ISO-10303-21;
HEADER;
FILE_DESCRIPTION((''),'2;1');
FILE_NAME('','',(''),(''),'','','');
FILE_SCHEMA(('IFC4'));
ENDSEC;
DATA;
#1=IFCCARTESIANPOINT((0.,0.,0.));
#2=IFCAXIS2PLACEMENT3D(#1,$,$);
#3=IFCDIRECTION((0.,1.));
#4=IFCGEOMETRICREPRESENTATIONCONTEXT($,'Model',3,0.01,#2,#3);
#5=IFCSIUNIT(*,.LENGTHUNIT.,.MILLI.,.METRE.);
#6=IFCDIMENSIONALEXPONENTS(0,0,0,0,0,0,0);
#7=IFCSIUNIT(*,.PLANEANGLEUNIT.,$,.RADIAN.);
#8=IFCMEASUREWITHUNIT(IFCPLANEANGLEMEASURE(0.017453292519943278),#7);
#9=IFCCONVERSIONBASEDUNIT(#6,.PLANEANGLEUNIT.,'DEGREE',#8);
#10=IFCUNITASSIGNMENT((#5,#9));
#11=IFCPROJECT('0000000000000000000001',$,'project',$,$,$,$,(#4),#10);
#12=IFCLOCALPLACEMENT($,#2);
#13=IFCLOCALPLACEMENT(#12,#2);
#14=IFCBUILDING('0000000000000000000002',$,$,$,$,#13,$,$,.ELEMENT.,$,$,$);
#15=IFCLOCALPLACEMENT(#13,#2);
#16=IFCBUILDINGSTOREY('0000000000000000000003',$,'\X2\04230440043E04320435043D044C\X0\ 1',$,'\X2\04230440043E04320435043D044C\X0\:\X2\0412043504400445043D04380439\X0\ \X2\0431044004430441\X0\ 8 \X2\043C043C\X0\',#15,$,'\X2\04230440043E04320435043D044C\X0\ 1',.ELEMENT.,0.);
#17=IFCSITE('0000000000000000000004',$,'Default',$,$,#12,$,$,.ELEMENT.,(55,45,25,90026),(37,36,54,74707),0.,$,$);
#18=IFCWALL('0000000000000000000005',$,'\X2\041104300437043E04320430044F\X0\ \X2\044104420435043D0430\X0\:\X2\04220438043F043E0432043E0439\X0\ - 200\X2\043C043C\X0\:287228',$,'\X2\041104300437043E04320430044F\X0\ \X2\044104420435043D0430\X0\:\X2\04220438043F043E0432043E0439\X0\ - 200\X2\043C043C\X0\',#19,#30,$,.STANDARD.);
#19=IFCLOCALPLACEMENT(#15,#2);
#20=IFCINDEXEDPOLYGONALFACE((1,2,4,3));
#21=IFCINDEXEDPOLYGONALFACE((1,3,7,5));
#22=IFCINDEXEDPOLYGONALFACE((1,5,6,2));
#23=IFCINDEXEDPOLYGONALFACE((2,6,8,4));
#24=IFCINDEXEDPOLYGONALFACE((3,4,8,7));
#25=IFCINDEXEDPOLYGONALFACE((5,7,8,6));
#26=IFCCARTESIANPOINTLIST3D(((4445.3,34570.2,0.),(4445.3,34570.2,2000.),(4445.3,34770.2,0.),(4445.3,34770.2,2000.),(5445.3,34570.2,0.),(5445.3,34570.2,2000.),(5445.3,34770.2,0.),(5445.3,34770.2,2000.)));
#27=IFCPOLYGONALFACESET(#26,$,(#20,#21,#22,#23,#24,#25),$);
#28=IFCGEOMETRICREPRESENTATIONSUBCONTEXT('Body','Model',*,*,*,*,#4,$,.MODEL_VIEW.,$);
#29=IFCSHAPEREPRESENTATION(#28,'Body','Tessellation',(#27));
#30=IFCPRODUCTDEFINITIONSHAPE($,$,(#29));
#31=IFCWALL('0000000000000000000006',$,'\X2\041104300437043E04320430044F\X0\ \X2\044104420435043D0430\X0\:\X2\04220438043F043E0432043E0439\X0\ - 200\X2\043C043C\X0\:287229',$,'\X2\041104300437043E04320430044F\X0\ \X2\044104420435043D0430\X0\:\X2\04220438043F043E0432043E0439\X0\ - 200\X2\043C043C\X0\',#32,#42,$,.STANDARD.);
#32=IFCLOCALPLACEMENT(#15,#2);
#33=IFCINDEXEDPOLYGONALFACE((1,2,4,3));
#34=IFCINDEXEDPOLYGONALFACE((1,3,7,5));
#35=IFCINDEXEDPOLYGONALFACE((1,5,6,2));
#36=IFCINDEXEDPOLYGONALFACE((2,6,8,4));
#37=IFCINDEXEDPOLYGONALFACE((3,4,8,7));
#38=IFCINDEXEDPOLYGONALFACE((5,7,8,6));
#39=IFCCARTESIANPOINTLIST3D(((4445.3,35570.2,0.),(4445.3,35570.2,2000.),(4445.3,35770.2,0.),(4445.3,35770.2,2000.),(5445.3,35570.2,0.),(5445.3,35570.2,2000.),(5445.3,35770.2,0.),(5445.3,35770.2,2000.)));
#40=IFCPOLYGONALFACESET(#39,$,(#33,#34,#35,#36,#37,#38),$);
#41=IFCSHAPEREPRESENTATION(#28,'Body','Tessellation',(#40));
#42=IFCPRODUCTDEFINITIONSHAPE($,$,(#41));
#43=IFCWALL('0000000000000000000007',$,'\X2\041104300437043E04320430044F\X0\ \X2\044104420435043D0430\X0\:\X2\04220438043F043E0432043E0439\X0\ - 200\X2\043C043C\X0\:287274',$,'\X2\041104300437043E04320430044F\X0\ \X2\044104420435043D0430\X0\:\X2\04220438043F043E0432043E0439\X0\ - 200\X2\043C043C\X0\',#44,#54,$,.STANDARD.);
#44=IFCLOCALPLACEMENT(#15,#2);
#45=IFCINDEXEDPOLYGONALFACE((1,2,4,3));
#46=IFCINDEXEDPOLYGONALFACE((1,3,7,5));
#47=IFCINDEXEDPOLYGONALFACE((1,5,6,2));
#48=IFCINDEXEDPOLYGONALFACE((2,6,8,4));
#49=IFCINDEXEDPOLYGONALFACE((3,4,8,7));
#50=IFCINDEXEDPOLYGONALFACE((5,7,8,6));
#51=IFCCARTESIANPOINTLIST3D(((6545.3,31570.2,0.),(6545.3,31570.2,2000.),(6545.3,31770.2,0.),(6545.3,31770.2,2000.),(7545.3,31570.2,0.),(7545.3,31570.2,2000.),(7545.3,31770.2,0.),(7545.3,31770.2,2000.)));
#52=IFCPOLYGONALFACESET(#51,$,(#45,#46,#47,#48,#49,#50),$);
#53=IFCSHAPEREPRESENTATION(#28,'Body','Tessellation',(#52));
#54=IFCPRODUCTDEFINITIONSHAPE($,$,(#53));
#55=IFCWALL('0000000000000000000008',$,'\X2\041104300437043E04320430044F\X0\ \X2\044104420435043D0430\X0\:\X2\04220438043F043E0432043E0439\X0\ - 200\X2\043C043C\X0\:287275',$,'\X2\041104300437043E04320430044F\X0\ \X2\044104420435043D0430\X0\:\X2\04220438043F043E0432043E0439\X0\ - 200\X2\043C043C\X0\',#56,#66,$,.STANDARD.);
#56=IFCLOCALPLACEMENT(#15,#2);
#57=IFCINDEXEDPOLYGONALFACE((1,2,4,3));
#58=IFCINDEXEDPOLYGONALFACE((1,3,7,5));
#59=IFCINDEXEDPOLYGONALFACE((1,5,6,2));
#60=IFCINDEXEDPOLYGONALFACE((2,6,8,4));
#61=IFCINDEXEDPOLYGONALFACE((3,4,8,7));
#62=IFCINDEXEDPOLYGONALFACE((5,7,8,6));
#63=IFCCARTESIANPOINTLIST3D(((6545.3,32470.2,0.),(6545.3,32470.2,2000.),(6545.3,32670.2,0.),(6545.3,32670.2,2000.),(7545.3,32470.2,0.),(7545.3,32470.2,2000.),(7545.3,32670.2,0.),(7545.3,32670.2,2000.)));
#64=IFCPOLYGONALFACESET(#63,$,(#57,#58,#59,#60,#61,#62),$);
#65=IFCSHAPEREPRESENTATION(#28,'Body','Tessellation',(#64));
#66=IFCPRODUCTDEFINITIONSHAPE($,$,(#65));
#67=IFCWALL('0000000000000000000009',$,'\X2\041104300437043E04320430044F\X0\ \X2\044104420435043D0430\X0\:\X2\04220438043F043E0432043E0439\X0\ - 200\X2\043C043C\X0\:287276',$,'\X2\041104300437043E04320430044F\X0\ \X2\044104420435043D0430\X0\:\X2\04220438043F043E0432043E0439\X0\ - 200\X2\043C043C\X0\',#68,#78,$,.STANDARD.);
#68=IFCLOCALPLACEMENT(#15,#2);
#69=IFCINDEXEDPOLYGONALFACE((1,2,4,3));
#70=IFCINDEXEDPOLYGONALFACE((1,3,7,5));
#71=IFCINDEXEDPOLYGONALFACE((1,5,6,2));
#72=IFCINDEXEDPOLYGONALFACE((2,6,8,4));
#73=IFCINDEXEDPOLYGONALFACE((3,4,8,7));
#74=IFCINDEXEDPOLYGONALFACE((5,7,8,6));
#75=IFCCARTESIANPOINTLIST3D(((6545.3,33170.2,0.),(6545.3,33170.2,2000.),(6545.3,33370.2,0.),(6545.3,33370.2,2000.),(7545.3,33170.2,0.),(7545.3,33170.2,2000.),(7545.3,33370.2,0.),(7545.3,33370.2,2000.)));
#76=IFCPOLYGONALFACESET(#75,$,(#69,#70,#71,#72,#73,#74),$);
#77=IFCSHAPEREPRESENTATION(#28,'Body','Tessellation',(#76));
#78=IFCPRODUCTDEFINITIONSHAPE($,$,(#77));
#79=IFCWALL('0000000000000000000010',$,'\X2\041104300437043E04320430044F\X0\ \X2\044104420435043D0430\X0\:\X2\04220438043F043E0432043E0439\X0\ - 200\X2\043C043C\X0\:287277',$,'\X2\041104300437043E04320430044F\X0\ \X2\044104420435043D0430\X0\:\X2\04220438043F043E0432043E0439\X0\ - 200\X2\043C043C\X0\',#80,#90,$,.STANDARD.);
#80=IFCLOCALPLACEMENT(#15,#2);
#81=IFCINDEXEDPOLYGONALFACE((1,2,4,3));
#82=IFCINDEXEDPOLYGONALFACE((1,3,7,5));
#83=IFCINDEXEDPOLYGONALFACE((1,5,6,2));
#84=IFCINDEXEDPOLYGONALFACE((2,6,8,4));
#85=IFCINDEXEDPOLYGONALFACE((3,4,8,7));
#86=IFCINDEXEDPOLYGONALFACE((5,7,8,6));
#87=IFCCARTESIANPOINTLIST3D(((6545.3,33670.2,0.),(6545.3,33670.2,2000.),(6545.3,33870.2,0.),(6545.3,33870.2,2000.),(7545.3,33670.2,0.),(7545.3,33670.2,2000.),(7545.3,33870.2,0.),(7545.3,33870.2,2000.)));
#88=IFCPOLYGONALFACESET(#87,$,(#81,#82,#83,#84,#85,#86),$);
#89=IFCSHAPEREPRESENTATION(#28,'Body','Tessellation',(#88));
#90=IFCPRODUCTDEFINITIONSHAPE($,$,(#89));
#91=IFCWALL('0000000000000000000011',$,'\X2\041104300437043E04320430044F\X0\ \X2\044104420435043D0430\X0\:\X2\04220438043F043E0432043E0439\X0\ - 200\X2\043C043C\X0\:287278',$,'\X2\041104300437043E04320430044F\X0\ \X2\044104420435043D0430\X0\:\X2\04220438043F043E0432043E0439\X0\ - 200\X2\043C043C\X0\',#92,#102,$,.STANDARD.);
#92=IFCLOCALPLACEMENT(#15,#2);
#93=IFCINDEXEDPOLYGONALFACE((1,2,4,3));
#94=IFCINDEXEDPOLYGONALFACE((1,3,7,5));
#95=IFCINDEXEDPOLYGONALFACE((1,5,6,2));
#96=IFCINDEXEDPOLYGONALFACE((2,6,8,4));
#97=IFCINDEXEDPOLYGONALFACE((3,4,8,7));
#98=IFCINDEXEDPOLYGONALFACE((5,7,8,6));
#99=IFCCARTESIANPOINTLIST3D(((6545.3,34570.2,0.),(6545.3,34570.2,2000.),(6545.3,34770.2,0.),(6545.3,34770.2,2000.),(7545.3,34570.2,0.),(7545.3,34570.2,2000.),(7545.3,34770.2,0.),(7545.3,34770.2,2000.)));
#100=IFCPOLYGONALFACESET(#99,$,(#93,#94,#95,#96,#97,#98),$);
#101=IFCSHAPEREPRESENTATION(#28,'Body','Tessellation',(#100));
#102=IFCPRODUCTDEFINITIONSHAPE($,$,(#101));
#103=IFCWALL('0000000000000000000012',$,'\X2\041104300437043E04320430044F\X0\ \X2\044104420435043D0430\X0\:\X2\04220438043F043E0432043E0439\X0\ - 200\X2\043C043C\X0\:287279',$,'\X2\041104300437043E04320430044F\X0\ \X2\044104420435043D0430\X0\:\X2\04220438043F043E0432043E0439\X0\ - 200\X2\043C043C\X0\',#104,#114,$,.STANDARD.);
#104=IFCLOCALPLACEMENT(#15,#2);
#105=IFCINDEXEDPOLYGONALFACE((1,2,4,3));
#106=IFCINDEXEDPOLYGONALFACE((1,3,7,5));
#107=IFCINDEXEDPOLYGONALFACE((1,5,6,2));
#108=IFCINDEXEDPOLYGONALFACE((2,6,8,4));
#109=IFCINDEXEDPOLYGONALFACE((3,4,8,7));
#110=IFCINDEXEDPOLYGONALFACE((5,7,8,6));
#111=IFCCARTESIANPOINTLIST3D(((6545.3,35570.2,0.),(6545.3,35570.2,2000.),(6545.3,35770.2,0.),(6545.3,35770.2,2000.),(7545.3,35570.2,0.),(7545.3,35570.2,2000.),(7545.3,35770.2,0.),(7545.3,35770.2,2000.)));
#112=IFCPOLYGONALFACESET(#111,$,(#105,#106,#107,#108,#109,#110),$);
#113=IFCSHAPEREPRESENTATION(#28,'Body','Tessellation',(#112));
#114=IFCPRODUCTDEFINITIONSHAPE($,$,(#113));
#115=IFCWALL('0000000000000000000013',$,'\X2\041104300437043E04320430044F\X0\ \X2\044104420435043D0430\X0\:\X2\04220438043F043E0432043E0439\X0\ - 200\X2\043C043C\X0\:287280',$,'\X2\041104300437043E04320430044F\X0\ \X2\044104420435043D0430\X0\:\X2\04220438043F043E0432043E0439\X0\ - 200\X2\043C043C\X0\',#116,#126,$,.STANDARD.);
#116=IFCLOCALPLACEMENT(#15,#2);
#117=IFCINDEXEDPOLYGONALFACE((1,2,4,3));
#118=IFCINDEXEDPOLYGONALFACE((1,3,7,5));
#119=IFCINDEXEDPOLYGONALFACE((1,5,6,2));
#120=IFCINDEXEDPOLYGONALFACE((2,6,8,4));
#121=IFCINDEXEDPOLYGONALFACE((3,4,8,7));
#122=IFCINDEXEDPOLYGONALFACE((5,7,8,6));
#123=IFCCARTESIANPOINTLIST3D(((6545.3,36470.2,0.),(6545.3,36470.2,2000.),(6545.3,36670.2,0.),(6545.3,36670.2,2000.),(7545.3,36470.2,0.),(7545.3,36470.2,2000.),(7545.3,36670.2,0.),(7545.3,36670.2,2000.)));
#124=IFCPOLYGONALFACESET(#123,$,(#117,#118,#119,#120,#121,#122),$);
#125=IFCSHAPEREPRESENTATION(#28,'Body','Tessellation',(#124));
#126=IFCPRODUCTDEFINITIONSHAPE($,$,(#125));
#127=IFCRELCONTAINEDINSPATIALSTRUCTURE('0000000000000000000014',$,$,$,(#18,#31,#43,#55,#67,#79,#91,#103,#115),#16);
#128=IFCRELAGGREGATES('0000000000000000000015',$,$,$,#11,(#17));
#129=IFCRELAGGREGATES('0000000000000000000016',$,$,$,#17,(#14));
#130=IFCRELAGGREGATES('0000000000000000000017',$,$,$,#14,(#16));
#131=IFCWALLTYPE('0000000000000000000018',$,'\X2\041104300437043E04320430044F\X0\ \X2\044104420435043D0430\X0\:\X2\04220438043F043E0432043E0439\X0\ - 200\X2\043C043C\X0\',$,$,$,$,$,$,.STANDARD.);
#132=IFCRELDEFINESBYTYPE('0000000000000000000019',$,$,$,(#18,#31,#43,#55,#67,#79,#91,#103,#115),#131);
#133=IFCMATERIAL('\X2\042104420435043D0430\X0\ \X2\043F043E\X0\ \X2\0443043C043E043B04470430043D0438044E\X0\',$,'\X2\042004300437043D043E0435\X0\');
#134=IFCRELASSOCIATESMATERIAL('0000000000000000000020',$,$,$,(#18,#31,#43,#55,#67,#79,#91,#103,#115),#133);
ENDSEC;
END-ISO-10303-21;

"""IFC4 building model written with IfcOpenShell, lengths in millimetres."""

from ifc_helpers import new_model, entity, si_unit, converted_unit, direction, frame, origin, place, context, subcontext, project, spatial, indexed_curve, outline, extrude, material, type_object, element, save


model = new_model("IFC4")

# Units and contexts
model_context = context("Model", 3, precision=0.01, world=origin(), true_north=direction((0.0, 1.0)))
body_context = subcontext(model_context, "Body", "Model", "MODEL_VIEW")
ifc_project = project(units=[si_unit("LENGTHUNIT", "METRE", prefix="MILLI"), converted_unit("PLANEANGLEUNIT", "DEGREE", entity("IfcPlaneAngleMeasure", 0.017453292519943278), si_unit("PLANEANGLEUNIT", "RADIAN"), dimensions=[0, 0, 0, 0, 0, 0, 0])], contexts=[model_context])

# Site, building, storey
site_placement = place(None, origin())
site = spatial("IfcSite", under=ifc_project, at=site_placement, Name="Default", CompositionType="ELEMENT", RefLatitude=(55, 45, 25, 90026), RefLongitude=(37, 36, 54, 74707), RefElevation=0.0)
building_placement = place(site_placement, origin())
building = spatial("IfcBuilding", under=site, at=building_placement, CompositionType="ELEMENT")
storey_placement = place(building_placement, origin())
storey = spatial("IfcBuildingStorey", under=building, at=storey_placement, Name="Уровень 1", ObjectType="Уровень:Верхний брус 8 мм", LongName="Уровень 1", CompositionType="ELEMENT", Elevation=0.0)

# Walls
ifc_material = material(Name="Стена по умолчанию", Category="Разное")
wall_type = type_object("IfcWallType", Name="Базовая стена:Типовой - 200мм", PredefinedType="STANDARD")
for number, where, name in (
    (1, (4445.3, 34670.2, 0.0), "Базовая стена:Типовой - 200мм:287228"),
    (2, (4445.3, 35670.2, 0.0), "Базовая стена:Типовой - 200мм:287229"),
):
    element("IfcWall", number, at=place(storey_placement, frame(where)), inside=storey, type_object=wall_type, material=ifc_material, Name=name, ObjectType="Базовая стена:Типовой - 200мм", PredefinedType="STANDARD", context=body_context, shape_type="SweptSolid", body=[
        extrude(outline(indexed_curve([(1000.0, 100.0), (0.0, 100.0), (0.0, -100.0), (1000.0, -100.0), (1000.0, 100.0)], self_intersect=False)), origin(), (0.0, 0.0, 1.0), 2000.0),
    ])
wall_1_placement = place(storey_placement, frame((6545.3, 31670.2, 0.0)))
element("IfcWall", 3, at=wall_1_placement, inside=storey, type_object=wall_type, material=ifc_material, Name="Базовая стена:Типовой - 200мм:287274", ObjectType="Базовая стена:Типовой - 200мм", PredefinedType="STANDARD", context=body_context, shape_type="SweptSolid", body=[
    extrude(outline(indexed_curve([(1000.0, 100.0), (0.0, 100.0), (0.0, -100.0), (1000.0, -100.0), (1000.0, 100.0)], self_intersect=False)), origin(), (0.0, 0.0, 1.0), 2000.0),
])
for number, where, name in (
    (4, (6545.3, 32570.2, 0.0), "Базовая стена:Типовой - 200мм:287275"),
    (5, (6545.3, 33270.2, 0.0), "Базовая стена:Типовой - 200мм:287276"),
):
    element("IfcWall", number, at=place(storey_placement, frame(where)), inside=storey, type_object=wall_type, material=ifc_material, Name=name, ObjectType="Базовая стена:Типовой - 200мм", PredefinedType="STANDARD", context=body_context, shape_type="SweptSolid", body=[
        extrude(outline(indexed_curve([(1000.0, 100.0), (0.0, 100.0), (0.0, -100.0), (1000.0, -100.0), (1000.0, 100.0)], self_intersect=False)), origin(), (0.0, 0.0, 1.0), 2000.0),
    ])
for number, where, name in (
    (6, (6545.3, 33770.2, 0.0), "Базовая стена:Типовой - 200мм:287277"),
    (7, (6545.3, 34670.2, 0.0), "Базовая стена:Типовой - 200мм:287278"),
    (8, (6545.3, 35670.2, 0.0), "Базовая стена:Типовой - 200мм:287279"),
):
    element("IfcWall", number, at=place(storey_placement, frame(where)), inside=storey, type_object=wall_type, material=ifc_material, Name=name, ObjectType="Базовая стена:Типовой - 200мм", PredefinedType="STANDARD", context=body_context, shape_type="SweptSolid", body=[
        extrude(outline(indexed_curve([(1000.0, 100.0), (0.0, 100.0), (0.0, -100.0), (1000.0, -100.0), (1000.0, 100.0)], self_intersect=False)), origin(), (0.0, 0.0, 1.0), 2000.0),
    ])
wall_2_placement = place(storey_placement, frame((6545.3, 36570.2, 0.0)))
element("IfcWall", 9, at=wall_2_placement, inside=storey, type_object=wall_type, material=ifc_material, Name="Базовая стена:Типовой - 200мм:287280", ObjectType="Базовая стена:Типовой - 200мм", PredefinedType="STANDARD", context=body_context, shape_type="SweptSolid", body=[
    extrude(outline(indexed_curve([(1000.0, 100.0), (0.0, 100.0), (0.0, -100.0), (1000.0, -100.0), (1000.0, 100.0)], self_intersect=False)), origin(), (0.0, 0.0, 1.0), 2000.0),
])

save(model, "model.ifc")
